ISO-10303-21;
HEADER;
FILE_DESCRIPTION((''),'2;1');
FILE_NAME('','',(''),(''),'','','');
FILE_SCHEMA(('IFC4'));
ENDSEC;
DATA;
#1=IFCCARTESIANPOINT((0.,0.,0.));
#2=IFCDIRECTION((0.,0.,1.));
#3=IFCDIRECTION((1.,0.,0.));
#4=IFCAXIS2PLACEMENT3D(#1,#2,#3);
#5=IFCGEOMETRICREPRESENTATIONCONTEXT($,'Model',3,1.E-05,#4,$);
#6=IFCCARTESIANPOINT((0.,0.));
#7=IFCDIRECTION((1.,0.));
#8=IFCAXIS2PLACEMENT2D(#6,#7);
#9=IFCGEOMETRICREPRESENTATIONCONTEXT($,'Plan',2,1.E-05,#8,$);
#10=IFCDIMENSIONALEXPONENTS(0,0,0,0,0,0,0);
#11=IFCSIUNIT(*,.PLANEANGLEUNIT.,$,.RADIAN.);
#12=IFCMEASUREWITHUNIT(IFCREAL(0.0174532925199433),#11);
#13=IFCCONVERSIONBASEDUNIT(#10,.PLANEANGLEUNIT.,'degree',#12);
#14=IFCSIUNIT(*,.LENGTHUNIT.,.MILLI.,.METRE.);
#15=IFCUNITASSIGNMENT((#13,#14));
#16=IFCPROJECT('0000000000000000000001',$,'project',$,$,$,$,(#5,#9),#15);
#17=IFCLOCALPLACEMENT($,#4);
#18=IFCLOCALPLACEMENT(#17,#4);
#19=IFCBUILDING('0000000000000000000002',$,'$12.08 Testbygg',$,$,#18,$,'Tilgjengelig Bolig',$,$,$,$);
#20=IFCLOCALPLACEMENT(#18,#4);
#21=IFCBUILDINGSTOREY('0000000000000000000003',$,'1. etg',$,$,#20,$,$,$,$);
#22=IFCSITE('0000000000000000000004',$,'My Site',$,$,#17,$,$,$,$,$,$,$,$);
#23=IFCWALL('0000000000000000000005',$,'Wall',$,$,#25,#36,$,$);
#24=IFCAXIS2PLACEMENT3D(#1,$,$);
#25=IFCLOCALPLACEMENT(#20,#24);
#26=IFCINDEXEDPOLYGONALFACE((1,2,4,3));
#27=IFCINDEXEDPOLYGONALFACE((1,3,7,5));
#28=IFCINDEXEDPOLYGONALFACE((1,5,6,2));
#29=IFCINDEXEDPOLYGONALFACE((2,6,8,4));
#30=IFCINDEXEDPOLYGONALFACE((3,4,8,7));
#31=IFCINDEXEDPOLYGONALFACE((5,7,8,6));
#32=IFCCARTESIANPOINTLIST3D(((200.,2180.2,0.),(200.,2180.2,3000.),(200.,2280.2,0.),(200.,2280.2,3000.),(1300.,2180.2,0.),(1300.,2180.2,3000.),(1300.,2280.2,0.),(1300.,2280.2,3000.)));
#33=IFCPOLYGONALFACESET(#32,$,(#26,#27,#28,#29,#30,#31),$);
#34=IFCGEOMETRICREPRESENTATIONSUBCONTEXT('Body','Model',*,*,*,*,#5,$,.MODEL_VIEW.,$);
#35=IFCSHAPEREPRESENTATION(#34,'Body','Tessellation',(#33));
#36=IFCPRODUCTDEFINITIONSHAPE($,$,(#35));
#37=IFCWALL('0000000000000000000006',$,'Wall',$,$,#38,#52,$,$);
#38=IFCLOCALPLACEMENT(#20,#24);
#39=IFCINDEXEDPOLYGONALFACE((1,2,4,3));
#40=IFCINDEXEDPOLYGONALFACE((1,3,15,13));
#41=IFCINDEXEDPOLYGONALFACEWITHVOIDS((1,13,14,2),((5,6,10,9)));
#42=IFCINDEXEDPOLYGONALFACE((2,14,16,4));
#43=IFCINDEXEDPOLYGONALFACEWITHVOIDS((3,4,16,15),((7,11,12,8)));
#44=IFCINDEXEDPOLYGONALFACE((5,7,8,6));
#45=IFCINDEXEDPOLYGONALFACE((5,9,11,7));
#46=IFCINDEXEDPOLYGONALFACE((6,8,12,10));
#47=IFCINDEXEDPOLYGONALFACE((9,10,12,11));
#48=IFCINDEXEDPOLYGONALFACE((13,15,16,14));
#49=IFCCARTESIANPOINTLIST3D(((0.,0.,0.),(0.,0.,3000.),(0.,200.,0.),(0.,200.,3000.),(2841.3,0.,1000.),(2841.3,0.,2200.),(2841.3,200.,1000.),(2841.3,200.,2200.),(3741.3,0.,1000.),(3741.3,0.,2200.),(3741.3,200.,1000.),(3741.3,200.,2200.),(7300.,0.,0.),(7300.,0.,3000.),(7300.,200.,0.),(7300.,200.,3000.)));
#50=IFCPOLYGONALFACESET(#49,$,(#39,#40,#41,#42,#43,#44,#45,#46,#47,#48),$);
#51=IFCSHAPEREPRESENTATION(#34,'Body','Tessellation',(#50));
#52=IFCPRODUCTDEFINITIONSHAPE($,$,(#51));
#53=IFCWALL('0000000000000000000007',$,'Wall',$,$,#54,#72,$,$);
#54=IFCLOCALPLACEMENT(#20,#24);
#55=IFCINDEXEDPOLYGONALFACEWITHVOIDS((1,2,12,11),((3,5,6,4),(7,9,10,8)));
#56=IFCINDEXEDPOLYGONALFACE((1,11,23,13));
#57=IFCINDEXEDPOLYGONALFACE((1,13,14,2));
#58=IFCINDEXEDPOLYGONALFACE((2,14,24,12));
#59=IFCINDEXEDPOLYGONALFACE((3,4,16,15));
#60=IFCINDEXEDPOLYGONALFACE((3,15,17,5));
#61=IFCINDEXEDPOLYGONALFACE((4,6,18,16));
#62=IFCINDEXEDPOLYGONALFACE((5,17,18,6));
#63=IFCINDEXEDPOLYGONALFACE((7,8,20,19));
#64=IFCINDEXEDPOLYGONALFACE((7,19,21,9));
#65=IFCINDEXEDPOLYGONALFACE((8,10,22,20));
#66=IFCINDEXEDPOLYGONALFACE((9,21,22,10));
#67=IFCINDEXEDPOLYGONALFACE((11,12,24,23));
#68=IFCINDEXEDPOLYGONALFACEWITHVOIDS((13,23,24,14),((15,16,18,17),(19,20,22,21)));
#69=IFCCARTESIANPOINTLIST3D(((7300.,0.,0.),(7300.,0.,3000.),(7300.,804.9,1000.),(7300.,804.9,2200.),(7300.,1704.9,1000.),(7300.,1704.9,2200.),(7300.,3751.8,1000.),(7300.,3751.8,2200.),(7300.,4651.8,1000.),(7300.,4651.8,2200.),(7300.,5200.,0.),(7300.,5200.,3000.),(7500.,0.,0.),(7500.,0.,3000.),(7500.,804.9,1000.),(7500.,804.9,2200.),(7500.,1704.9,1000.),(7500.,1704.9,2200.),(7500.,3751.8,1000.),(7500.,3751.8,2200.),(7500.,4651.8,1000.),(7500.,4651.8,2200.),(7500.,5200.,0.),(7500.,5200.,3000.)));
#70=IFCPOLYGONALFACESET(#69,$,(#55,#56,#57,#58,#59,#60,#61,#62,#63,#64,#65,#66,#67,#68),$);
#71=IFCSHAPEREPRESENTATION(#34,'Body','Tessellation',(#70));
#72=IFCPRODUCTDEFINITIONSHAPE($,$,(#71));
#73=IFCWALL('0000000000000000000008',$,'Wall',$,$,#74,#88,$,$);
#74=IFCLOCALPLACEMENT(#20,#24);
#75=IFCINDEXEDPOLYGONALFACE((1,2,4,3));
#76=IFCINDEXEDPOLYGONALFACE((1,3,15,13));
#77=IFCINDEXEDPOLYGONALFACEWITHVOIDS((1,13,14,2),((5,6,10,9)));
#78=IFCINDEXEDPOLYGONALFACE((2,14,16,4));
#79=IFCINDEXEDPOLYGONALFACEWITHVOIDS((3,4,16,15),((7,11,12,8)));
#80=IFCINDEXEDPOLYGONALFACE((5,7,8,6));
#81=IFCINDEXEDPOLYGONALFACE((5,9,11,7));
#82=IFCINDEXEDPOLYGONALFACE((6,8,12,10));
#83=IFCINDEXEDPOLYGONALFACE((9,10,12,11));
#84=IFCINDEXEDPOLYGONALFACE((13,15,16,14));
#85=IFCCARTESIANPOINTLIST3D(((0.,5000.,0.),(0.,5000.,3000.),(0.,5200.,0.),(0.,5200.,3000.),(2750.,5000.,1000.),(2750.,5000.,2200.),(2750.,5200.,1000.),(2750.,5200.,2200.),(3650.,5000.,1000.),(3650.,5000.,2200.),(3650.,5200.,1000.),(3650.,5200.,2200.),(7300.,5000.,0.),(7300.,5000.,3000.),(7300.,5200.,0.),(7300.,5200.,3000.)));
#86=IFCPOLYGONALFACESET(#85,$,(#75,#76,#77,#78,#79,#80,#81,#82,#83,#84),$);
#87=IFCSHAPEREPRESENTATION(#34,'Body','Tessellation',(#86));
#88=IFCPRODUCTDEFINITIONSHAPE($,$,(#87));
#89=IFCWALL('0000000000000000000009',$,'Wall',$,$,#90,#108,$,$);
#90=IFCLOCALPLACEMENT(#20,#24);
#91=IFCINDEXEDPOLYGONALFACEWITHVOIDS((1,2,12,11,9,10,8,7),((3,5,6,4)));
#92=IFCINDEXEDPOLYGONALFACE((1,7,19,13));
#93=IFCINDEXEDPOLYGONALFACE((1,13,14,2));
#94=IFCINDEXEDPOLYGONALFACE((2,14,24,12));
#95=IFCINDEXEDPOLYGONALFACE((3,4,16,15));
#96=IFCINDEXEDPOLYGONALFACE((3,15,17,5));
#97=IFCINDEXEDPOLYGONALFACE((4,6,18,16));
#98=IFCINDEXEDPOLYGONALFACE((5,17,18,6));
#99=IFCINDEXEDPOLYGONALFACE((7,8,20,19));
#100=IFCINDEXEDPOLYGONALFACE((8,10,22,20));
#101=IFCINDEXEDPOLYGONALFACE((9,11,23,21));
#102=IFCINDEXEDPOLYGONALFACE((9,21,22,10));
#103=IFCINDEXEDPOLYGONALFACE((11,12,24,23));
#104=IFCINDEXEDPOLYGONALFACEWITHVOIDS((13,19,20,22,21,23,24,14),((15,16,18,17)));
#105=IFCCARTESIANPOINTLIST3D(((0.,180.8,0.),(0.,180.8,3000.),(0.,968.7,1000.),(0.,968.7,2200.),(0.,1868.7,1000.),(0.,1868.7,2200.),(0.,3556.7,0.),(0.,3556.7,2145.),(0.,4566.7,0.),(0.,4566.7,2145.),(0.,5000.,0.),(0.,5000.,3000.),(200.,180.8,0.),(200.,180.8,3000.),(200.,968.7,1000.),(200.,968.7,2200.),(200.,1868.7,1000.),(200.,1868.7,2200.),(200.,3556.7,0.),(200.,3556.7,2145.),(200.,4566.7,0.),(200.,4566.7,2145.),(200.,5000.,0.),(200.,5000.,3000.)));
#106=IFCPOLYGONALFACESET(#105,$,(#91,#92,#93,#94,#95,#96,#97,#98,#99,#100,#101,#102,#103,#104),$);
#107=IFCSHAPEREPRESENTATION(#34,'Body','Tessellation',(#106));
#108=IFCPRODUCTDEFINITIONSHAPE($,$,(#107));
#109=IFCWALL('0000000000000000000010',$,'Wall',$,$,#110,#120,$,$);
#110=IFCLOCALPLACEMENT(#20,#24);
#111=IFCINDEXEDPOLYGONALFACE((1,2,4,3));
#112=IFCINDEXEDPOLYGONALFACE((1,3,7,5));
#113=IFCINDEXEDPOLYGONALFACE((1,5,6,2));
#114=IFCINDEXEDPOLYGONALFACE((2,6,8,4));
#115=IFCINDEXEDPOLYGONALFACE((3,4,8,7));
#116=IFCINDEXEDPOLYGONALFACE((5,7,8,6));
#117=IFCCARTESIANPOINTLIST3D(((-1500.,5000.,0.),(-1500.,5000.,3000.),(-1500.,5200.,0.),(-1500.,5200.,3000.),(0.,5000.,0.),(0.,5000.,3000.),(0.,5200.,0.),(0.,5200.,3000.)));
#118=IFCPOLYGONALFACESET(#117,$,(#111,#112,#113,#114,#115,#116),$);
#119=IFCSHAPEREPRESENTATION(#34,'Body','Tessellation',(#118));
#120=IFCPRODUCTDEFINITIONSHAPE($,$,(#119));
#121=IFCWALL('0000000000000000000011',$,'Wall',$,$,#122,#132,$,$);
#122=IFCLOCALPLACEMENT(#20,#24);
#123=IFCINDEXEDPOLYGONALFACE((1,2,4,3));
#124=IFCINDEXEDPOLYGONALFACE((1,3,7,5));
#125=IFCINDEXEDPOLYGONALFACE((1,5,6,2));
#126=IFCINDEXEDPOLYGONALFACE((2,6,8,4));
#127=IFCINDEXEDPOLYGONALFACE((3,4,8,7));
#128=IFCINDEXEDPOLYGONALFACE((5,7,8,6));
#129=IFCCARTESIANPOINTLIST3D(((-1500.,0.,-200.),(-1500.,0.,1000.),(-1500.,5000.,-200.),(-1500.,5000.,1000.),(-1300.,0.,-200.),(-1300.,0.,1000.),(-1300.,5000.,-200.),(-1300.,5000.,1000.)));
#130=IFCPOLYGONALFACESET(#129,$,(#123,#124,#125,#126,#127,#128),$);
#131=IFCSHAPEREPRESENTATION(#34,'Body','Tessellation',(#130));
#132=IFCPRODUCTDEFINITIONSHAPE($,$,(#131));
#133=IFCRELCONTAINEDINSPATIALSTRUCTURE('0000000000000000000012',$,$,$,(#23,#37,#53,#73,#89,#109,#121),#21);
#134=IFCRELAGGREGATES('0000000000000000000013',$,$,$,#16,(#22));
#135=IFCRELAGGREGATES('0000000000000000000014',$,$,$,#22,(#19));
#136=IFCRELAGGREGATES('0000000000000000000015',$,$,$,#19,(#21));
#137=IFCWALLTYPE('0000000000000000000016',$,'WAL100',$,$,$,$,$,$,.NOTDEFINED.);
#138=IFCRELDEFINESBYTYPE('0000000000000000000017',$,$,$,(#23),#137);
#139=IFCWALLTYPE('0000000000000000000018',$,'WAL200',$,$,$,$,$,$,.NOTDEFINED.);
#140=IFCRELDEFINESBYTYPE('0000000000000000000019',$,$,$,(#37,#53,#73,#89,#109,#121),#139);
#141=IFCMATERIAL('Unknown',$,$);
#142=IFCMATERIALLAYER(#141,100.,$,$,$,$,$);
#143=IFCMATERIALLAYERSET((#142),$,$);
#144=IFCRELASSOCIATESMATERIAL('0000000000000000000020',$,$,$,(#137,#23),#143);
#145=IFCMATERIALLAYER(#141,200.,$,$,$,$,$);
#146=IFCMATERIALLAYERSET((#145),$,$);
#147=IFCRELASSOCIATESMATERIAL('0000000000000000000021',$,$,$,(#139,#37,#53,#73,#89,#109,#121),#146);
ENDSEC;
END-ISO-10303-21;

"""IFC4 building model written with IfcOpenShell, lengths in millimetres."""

from ifc_helpers import new_model, entity, si_unit, converted_unit, frame, origin_with_axes, origin_2d_with_axis, place, context, subcontext, project, spatial, line, indexed_curve, outline, extrude, source, transform, mapped, material, layer, layer_set, layer_usage, type_object, element, save


model = new_model("IFC4")

# Units and contexts
model_context = context("Model", 3, precision=1e-05, world=origin_with_axes())
plan_context = context("Plan", 2, precision=1e-05, world=origin_2d_with_axis())
body_context = subcontext(model_context, "Body", "Model", "MODEL_VIEW")
ifc_project = project(units=[converted_unit("PLANEANGLEUNIT", "degree", entity("IfcReal", 0.0174532925199433), si_unit("PLANEANGLEUNIT", "RADIAN"), dimensions=[0, 0, 0, 0, 0, 0, 0]), si_unit("LENGTHUNIT", "METRE", prefix="MILLI")], contexts=[model_context, plan_context])

# Site, building, storey
site_placement = place(None, origin_with_axes())
site = spatial("IfcSite", under=ifc_project, at=site_placement, Name="My Site")
building_placement = place(site_placement, origin_with_axes())
building = spatial("IfcBuilding", under=site, at=building_placement, Name="$12.08 Testbygg", LongName="Tilgjengelig Bolig")
storey_placement = place(building_placement, origin_with_axes())
storey = spatial("IfcBuildingStorey", under=building, at=storey_placement, Name="1. etg")

# Shared definitions
ifc_material = material(Name="Unknown")

# Shared definitions
ifc_layer_1 = layer(ifc_material, 100.0)
ifc_layer_set_1 = layer_set([ifc_layer_1])
wall_type_1 = type_object("IfcWallType", Name="WAL100", PredefinedType="NOTDEFINED", material=ifc_layer_set_1)
shared_shape_1 = source(origin_with_axes(), body_context, "Body", "SweptSolid", [
    extrude(outline(indexed_curve([(0.0, 0.0), (1010.0, 0.0), (1010.0, 2145.0), (0.0, 2145.0)], segments=[line(1, 2), line(2, 3), line(3, 4), line(4, 1)])), frame((0.0, -100.0, 0.0), z_axis=(0.0, -1.0, 0.0), x_axis=(1.0, 0.0, 0.0)), (0.0, 0.0, -1.0), 400.0),
])

# Wall
ifc_layer_usage_1 = layer_usage(ifc_layer_set_1, "AXIS2", "POSITIVE", 0.0)
wall_1_placement = place(storey_placement, frame((200.0, 2180.2, 0.0), z_axis=(0.0, 0.0, 1.0), x_axis=(1.0, 0.0, 0.0)))
element("IfcWall", 1, at=wall_1_placement, inside=storey, type_object=wall_type_1, material=ifc_layer_usage_1, Name="Wall", context=body_context, shape_type="SweptSolid", body=[
    extrude(outline(indexed_curve([(0.0, 0.0), (0.0, 100.0), (1100.0, 100.0), (1100.0, 0.0), (0.0, 0.0)], self_intersect=False)), origin_with_axes(), (0.0, 0.0, 1.0), 3000.0),
])

# Wall, opening
ifc_layer_2 = layer(ifc_material, 200.0)
ifc_layer_set_2 = layer_set([ifc_layer_2])
ifc_layer_usage_2 = layer_usage(ifc_layer_set_2, "AXIS2", "POSITIVE", 0.0)
wall_type_2 = type_object("IfcWallType", Name="WAL200", PredefinedType="NOTDEFINED", material=ifc_layer_set_2)
wall_2_placement = place(storey_placement, origin_with_axes())
wall_2 = element("IfcWall", 2, at=wall_2_placement, inside=storey, type_object=wall_type_2, material=ifc_layer_usage_2, Name="Wall", context=body_context, shape_type="SweptSolid", body=[
    extrude(outline(indexed_curve([(0.0, 0.0), (0.0, 200.0), (7300.0, 200.0), (7300.0, 0.0), (0.0, 0.0)], self_intersect=False)), origin_with_axes(), (0.0, 0.0, 1.0), 3000.0),
])
shared_shape_2 = source(origin_with_axes(), body_context, "Body", "SweptSolid", [
    extrude(outline(indexed_curve([(0.0, 0.0), (900.0, 0.0), (900.0, 1200.0), (0.0, 1200.0)], segments=[line(1, 2), line(2, 3), line(3, 4), line(4, 1)])), frame((0.0, -100.0, 0.0), z_axis=(0.0, -1.0, 0.0), x_axis=(1.0, 0.0, 0.0)), (0.0, 0.0, -1.0), 400.0),
])
opening_1_placement = place(wall_2_placement, frame((2841.3, 0.0, 1000.0), z_axis=(0.0, 0.0, 1.0), x_axis=(1.0, 0.0, 0.0)))
element("IfcOpeningElement", 3, at=opening_1_placement, cuts=wall_2, PredefinedType="OPENING", context=body_context, shape_type="MappedRepresentation", body=[
    mapped(shared_shape_2, transform((0.0, 0.0, 0.0), x_axis=(1.0, 0.0, 0.0), y_axis=(0.0, 1.0, 0.0), z_axis=(0.0, 0.0, 1.0), scale=1.0)),
])

# Wall, openings
ifc_layer_usage_3 = layer_usage(ifc_layer_set_2, "AXIS2", "POSITIVE", 0.0)
wall_3_placement = place(storey_placement, frame((7500.0, 0.0, 0.0), z_axis=(0.0, 0.0, 1.0), x_axis=(0.0, 1.0, 0.0)))
wall_3 = element("IfcWall", 4, at=wall_3_placement, inside=storey, type_object=wall_type_2, material=ifc_layer_usage_3, Name="Wall", context=body_context, shape_type="SweptSolid", body=[
    extrude(outline(indexed_curve([(0.0, 0.0), (0.0, 200.0), (5200.0, 200.0), (5200.0, 0.0), (0.0, 0.0)], self_intersect=False)), origin_with_axes(), (0.0, 0.0, 1.0), 3000.0),
])
opening_2_placement = place(wall_3_placement, frame((3751.8, 0.0, 1000.0), z_axis=(0.0, 0.0, 1.0), x_axis=(1.0, 0.0, 0.0)))
element("IfcOpeningElement", 5, at=opening_2_placement, cuts=wall_3, PredefinedType="OPENING", context=body_context, shape_type="MappedRepresentation", body=[
    mapped(shared_shape_2, transform((0.0, 0.0, 0.0), x_axis=(1.0, 0.0, 0.0), y_axis=(0.0, 1.0, 0.0), z_axis=(0.0, 0.0, 1.0), scale=1.0)),
])
opening_3_placement = place(wall_3_placement, frame((804.9, 0.0, 1000.0), z_axis=(0.0, 0.0, 1.0), x_axis=(1.0, 0.0, 0.0)))
element("IfcOpeningElement", 6, at=opening_3_placement, cuts=wall_3, PredefinedType="OPENING", context=body_context, shape_type="MappedRepresentation", body=[
    mapped(shared_shape_2, transform((0.0, 0.0, 0.0), x_axis=(1.0, 0.0, 0.0), y_axis=(0.0, 1.0, 0.0), z_axis=(0.0, 0.0, 1.0), scale=1.0)),
])

# Wall, opening
ifc_layer_usage_4 = layer_usage(ifc_layer_set_2, "AXIS2", "POSITIVE", 0.0)
wall_4_placement = place(storey_placement, frame((7300.0, 5200.0, 0.0), z_axis=(0.0, 0.0, 1.0), x_axis=(-1.0, 0.0, 0.0)))
wall_4 = element("IfcWall", 7, at=wall_4_placement, inside=storey, type_object=wall_type_2, material=ifc_layer_usage_4, Name="Wall", context=body_context, shape_type="SweptSolid", body=[
    extrude(outline(indexed_curve([(0.0, 0.0), (0.0, 200.0), (7300.0, 200.0), (7300.0, 0.0), (0.0, 0.0)], self_intersect=False)), origin_with_axes(), (0.0, 0.0, 1.0), 3000.0),
])
opening_4_placement = place(wall_4_placement, frame((3650.0, 0.0, 1000.0), z_axis=(0.0, 0.0, 1.0), x_axis=(1.0, 0.0, 0.0)))
element("IfcOpeningElement", 8, at=opening_4_placement, cuts=wall_4, PredefinedType="OPENING", context=body_context, shape_type="MappedRepresentation", body=[
    mapped(shared_shape_2, transform((0.0, 0.0, 0.0), x_axis=(1.0, 0.0, 0.0), y_axis=(0.0, 1.0, 0.0), z_axis=(0.0, 0.0, 1.0), scale=1.0)),
])

# Wall, openings
ifc_layer_usage_5 = layer_usage(ifc_layer_set_2, "AXIS2", "POSITIVE", 0.0)
wall_5_placement = place(storey_placement, frame((0.0, 5000.0, 0.0), z_axis=(0.0, 0.0, 1.0), x_axis=(0.0, -1.0, 0.0)))
wall_5 = element("IfcWall", 9, at=wall_5_placement, inside=storey, type_object=wall_type_2, material=ifc_layer_usage_5, Name="Wall", context=body_context, shape_type="SweptSolid", body=[
    extrude(outline(indexed_curve([(0.0, 0.0), (0.0, 200.0), (4819.2, 200.0), (4819.2, 0.0), (0.0, 0.0)], self_intersect=False)), origin_with_axes(), (0.0, 0.0, 1.0), 3000.0),
])
opening_5_placement = place(wall_5_placement, frame((433.4, 0.0, 0.0), z_axis=(0.0, 0.0, 1.0), x_axis=(1.0, 0.0, 0.0)))
element("IfcOpeningElement", 10, at=opening_5_placement, cuts=wall_5, PredefinedType="OPENING", context=body_context, shape_type="MappedRepresentation", body=[
    mapped(shared_shape_1, transform((0.0, 0.0, 0.0), x_axis=(1.0, 0.0, 0.0), y_axis=(0.0, 1.0, 0.0), z_axis=(0.0, 0.0, 1.0), scale=1.0)),
])
opening_6_placement = place(wall_5_placement, frame((3131.3, 0.0, 1000.0), z_axis=(0.0, 0.0, 1.0), x_axis=(1.0, 0.0, 0.0)))
element("IfcOpeningElement", 11, at=opening_6_placement, cuts=wall_5, PredefinedType="OPENING", context=body_context, shape_type="MappedRepresentation", body=[
    mapped(shared_shape_2, transform((0.0, 0.0, 0.0), x_axis=(1.0, 0.0, 0.0), y_axis=(0.0, 1.0, 0.0), z_axis=(0.0, 0.0, 1.0), scale=1.0)),
])

# Walls
ifc_layer_usage_6 = layer_usage(ifc_layer_set_2, "AXIS2", "POSITIVE", 0.0)
wall_6_placement = place(storey_placement, frame((0.0, 5200.0, 0.0), z_axis=(0.0, 0.0, 1.0), x_axis=(-1.0, 0.000001, 0.0)))
element("IfcWall", 12, at=wall_6_placement, inside=storey, type_object=wall_type_2, material=ifc_layer_usage_6, Name="Wall", context=body_context, shape_type="SweptSolid", body=[
    extrude(outline(indexed_curve([(0.0, 0.0), (0.0, 200.0), (1500.0, 200.0), (1500.0, 0.0), (0.0, 0.0)], self_intersect=False)), origin_with_axes(), (0.0, 0.0, 1.0), 3000.0),
])
ifc_layer_usage_7 = layer_usage(ifc_layer_set_2, "AXIS2", "POSITIVE", 0.0)
wall_7_placement = place(storey_placement, frame((-1500.0, 5000.0, -200.0), z_axis=(0.0, 0.0, 1.0), x_axis=(-0.000001, -1.0, 0.0)))
element("IfcWall", 13, at=wall_7_placement, inside=storey, type_object=wall_type_2, material=ifc_layer_usage_7, Name="Wall", context=body_context, shape_type="SweptSolid", body=[
    extrude(outline(indexed_curve([(0.0, 0.0), (0.0, 200.0), (5000.0, 200.0), (5000.0, 0.0), (0.0, 0.0)], self_intersect=False)), origin_with_axes(), (0.0, 0.0, 1.0), 1200.0),
])

save(model, "model.ifc")
